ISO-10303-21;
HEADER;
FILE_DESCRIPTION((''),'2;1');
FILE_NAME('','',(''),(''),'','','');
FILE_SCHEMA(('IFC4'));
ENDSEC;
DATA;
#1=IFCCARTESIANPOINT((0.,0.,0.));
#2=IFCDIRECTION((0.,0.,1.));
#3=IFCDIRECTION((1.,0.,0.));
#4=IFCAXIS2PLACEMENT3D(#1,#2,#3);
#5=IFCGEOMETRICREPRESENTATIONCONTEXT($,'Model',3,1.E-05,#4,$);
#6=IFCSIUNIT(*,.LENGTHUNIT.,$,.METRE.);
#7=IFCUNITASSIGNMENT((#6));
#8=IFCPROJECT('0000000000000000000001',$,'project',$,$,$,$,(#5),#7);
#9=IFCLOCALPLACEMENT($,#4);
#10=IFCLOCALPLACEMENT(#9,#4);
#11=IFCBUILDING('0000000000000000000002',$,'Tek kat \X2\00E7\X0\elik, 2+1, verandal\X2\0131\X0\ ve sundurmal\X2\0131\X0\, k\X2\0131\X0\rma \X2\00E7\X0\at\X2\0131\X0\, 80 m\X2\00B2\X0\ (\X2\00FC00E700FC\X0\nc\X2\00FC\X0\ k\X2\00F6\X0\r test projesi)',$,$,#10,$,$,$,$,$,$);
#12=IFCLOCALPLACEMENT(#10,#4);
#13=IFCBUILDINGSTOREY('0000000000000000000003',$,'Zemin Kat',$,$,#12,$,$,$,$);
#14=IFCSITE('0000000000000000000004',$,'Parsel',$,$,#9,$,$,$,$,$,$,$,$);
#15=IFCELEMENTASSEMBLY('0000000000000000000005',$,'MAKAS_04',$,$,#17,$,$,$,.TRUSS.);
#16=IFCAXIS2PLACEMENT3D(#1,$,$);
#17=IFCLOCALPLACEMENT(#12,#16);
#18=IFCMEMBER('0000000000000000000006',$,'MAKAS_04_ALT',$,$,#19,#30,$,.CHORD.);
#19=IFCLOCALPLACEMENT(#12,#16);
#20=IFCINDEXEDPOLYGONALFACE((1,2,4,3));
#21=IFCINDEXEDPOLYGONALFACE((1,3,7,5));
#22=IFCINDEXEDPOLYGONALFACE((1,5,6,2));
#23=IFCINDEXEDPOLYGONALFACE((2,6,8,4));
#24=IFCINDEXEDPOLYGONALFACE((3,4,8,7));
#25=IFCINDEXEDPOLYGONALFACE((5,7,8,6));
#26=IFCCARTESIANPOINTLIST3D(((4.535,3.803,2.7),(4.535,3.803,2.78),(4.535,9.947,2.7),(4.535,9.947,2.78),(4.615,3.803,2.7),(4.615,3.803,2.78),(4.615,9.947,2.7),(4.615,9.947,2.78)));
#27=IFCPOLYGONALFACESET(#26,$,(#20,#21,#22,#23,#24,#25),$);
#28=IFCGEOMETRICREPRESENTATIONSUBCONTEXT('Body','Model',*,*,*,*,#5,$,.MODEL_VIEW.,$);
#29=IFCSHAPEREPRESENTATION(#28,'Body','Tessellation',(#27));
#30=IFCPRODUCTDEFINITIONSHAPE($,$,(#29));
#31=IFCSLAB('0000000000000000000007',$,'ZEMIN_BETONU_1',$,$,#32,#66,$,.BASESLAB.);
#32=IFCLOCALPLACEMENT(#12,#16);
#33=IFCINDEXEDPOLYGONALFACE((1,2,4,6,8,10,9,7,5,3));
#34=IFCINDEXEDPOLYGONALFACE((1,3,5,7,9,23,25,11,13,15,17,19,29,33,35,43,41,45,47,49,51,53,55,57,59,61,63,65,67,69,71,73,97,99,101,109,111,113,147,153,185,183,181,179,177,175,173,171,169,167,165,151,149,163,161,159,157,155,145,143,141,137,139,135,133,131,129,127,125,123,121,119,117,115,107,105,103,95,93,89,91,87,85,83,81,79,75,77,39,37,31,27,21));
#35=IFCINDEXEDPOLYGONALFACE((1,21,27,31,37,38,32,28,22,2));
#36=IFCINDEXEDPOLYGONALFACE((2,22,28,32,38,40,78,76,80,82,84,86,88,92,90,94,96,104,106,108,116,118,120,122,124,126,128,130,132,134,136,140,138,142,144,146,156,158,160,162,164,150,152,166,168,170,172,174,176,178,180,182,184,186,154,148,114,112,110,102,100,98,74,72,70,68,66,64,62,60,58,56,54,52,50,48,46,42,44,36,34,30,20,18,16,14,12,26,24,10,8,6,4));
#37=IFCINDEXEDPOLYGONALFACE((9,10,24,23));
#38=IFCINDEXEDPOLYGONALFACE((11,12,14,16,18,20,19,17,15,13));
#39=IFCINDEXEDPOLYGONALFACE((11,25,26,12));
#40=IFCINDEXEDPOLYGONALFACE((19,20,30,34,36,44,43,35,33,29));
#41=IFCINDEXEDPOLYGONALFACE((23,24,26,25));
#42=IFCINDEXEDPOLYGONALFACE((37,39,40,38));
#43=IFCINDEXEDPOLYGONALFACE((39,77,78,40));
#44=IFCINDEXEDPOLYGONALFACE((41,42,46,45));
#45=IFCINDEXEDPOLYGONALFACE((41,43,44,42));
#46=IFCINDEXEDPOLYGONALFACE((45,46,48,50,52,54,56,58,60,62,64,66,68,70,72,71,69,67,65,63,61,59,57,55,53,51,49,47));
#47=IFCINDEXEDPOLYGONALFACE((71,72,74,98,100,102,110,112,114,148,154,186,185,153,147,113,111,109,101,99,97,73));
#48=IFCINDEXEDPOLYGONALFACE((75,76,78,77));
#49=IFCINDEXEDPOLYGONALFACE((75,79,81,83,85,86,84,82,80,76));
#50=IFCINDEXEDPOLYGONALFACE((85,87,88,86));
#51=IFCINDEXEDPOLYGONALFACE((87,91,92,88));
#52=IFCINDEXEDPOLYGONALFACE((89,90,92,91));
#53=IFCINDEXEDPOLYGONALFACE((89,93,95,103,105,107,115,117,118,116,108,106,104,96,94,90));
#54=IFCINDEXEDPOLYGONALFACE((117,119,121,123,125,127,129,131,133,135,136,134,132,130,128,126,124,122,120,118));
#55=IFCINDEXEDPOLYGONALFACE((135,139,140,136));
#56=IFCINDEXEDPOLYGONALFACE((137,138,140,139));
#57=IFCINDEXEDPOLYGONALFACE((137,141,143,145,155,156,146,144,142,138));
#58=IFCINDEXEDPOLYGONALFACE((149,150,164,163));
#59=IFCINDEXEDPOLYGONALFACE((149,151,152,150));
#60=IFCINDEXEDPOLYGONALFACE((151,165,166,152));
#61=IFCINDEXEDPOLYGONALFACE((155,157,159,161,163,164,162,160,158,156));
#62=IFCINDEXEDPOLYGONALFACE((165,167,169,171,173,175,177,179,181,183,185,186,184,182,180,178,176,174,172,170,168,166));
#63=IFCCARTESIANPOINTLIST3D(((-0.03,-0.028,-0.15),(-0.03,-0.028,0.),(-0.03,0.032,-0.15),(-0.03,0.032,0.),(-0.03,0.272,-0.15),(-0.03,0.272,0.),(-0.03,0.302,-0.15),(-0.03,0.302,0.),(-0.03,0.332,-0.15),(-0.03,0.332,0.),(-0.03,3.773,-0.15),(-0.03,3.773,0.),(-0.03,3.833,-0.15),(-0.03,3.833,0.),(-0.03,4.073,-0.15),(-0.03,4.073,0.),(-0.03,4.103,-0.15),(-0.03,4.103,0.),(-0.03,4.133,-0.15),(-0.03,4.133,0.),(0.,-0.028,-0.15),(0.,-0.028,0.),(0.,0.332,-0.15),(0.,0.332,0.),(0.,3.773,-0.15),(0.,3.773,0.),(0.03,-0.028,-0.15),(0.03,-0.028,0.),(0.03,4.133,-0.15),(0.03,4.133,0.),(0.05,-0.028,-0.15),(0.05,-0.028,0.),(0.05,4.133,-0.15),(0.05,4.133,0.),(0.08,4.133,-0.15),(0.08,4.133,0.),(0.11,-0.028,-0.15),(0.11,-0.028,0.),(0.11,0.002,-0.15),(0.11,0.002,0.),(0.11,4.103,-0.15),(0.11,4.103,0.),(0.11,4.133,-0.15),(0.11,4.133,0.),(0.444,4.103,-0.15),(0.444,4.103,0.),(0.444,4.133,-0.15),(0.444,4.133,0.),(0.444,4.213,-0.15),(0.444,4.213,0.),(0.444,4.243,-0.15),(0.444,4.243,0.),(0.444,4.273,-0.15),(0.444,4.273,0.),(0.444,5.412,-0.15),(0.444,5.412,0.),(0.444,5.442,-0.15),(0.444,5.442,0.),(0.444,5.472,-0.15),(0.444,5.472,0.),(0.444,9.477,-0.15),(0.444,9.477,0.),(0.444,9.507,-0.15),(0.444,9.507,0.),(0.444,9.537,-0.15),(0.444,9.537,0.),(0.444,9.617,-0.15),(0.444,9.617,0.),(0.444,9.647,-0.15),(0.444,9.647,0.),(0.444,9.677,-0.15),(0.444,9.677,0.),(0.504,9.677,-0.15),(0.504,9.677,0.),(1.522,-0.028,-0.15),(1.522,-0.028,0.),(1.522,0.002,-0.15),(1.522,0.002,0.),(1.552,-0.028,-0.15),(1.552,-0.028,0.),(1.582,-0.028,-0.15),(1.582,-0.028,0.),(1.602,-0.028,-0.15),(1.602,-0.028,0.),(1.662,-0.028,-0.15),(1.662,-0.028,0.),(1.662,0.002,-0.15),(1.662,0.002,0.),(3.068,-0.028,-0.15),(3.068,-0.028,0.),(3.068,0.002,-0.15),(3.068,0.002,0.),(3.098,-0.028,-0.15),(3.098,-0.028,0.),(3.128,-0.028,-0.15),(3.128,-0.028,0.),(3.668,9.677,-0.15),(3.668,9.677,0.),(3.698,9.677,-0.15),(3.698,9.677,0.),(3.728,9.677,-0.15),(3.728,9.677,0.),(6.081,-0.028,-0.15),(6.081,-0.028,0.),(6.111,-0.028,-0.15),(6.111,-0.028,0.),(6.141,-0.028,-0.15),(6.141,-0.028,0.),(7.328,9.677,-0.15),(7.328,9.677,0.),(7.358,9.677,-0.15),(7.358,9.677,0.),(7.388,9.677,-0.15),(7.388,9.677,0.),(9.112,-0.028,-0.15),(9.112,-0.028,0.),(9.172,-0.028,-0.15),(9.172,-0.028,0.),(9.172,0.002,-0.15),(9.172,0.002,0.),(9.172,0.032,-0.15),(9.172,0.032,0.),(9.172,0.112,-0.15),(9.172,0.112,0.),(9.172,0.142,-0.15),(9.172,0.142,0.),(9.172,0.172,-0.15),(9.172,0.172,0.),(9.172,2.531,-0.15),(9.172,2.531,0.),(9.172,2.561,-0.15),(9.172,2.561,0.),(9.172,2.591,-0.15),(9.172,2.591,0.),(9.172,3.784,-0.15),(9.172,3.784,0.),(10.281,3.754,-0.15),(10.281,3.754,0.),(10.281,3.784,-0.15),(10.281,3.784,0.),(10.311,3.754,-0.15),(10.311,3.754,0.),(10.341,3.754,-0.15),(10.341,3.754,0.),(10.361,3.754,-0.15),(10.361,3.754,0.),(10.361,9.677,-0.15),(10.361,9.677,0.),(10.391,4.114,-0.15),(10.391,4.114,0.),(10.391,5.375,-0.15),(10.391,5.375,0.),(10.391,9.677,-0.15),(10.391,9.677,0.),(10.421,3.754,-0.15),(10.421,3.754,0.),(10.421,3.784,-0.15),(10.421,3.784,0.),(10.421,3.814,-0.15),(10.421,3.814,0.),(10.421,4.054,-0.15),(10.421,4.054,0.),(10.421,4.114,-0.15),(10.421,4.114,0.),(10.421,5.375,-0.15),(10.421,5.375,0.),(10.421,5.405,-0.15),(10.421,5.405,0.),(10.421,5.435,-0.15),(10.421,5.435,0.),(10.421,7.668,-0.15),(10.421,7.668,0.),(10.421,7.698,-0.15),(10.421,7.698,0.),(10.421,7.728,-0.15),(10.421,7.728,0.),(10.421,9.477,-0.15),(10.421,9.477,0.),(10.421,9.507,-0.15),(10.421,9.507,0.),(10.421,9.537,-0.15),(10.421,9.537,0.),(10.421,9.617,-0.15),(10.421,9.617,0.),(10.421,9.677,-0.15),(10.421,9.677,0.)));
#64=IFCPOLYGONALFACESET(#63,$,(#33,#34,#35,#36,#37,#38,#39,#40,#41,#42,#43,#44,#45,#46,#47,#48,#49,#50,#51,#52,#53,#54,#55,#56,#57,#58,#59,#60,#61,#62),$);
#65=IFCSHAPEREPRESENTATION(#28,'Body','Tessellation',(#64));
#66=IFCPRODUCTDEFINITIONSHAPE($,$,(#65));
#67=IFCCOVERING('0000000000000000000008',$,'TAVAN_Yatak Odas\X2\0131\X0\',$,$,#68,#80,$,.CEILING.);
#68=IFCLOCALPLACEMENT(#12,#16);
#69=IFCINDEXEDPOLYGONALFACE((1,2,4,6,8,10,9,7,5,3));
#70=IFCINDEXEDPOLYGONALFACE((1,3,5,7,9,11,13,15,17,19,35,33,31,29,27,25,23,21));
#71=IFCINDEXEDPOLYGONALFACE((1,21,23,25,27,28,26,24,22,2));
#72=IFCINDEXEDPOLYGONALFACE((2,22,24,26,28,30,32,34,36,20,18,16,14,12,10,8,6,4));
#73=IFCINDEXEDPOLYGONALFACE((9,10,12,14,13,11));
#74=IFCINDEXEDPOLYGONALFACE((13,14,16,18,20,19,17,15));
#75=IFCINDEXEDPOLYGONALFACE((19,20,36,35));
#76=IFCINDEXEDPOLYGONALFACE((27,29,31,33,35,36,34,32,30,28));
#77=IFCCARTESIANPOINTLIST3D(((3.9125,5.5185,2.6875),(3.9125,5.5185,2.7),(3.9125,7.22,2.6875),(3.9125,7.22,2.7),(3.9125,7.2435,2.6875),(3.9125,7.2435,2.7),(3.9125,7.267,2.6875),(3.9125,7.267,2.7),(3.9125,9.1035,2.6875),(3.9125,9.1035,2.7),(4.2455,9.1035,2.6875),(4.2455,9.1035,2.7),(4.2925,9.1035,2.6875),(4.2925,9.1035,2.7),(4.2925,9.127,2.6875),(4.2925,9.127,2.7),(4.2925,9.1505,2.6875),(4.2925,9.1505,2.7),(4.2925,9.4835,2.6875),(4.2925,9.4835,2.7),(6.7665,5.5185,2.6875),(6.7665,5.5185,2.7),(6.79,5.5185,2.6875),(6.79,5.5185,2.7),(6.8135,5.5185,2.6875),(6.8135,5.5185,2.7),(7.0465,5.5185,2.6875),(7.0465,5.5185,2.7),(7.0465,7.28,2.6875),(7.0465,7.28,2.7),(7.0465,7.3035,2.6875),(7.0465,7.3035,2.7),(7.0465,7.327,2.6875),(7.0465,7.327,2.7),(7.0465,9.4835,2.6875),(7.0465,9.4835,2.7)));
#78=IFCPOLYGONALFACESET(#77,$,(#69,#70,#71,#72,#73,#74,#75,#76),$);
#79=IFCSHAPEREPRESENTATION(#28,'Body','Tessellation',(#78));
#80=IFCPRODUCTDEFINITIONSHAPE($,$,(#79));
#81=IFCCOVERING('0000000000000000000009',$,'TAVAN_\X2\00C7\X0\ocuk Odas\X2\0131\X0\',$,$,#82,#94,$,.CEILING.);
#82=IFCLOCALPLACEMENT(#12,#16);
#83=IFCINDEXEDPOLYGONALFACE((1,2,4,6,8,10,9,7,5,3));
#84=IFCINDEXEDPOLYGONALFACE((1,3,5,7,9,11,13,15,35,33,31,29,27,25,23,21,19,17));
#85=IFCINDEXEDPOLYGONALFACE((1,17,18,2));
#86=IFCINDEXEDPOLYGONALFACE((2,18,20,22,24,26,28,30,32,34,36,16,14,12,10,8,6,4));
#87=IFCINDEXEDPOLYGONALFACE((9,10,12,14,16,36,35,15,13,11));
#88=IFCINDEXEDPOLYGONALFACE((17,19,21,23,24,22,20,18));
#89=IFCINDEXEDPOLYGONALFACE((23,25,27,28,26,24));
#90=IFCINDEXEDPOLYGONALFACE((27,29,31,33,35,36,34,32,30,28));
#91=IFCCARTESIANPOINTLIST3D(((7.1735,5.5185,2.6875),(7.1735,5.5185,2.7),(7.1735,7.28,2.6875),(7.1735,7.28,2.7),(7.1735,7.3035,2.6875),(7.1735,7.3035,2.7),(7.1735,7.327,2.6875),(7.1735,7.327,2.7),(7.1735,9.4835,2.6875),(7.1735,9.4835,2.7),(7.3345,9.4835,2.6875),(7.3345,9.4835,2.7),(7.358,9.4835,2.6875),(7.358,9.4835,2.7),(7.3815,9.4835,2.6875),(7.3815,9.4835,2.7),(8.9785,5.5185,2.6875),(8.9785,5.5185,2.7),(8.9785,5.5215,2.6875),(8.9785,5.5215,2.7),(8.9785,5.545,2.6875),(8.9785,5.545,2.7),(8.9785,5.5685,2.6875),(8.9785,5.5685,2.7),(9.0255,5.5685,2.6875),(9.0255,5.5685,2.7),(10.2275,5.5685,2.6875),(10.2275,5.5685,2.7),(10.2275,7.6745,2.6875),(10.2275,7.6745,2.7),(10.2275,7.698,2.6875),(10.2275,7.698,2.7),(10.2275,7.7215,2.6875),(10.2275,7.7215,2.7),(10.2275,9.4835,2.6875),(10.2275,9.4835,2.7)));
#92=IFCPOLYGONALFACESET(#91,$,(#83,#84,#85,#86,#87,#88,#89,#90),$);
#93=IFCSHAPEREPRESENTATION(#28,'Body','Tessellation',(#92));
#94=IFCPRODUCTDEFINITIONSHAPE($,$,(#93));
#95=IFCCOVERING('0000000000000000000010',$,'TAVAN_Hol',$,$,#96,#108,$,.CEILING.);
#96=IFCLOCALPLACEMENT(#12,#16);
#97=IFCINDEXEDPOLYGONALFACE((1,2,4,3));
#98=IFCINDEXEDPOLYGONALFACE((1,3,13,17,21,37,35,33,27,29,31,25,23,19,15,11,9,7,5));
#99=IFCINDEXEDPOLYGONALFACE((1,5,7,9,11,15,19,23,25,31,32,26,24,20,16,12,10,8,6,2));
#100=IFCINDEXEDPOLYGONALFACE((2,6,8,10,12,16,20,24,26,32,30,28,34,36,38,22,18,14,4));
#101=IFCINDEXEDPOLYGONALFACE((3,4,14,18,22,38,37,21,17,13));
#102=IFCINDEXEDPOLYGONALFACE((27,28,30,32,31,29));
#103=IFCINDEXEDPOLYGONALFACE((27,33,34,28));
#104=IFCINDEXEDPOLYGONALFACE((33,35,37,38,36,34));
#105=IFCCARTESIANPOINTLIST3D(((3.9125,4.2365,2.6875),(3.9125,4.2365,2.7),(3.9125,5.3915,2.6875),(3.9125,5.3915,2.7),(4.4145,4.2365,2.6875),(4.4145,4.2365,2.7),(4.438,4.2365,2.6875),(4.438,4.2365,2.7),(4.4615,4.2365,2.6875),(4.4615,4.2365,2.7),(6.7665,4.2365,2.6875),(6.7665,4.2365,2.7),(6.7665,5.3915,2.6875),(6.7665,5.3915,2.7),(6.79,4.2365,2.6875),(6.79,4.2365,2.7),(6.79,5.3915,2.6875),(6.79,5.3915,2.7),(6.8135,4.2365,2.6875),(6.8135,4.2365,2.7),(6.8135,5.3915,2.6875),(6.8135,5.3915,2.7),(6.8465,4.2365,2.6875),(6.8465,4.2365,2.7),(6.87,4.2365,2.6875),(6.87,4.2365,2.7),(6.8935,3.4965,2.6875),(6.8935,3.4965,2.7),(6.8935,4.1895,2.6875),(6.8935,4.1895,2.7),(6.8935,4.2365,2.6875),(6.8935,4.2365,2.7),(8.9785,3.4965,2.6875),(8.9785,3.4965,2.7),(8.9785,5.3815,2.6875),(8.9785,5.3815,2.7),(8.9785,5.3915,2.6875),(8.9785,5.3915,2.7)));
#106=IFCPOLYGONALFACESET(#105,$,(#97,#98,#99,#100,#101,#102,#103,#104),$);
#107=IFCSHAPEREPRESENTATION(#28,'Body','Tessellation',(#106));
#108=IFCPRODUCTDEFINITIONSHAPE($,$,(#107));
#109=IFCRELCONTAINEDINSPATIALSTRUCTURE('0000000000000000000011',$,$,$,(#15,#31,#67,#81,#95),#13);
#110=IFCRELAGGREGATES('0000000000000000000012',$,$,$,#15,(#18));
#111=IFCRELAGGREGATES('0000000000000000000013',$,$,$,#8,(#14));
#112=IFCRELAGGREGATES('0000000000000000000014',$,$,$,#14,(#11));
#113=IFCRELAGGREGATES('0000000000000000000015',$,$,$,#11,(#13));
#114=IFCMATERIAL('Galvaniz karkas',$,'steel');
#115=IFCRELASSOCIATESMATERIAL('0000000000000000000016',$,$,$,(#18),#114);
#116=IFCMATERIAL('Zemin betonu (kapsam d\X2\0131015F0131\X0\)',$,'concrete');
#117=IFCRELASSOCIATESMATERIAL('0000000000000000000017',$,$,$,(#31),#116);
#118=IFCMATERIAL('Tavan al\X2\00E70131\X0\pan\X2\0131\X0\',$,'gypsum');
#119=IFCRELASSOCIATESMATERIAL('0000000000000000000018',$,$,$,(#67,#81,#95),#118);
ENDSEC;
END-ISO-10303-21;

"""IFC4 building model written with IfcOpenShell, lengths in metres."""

from ifc_helpers import new_model, si_unit, frame, origin_with_axes, place, context, subcontext, project, spatial, line, indexed_curve, outline, extrude, material, element, aggregate, save


model = new_model("IFC4")

# Units and contexts
model_context = context("Model", 3, precision=1e-05, world=origin_with_axes())
body_context = subcontext(model_context, "Body", "Model", "MODEL_VIEW")
ifc_project = project(units=[si_unit("LENGTHUNIT", "METRE")], contexts=[model_context])

# Site, building, storey
site_placement = place(None, origin_with_axes())
site = spatial("IfcSite", under=ifc_project, at=site_placement, Name="Parsel")
building_placement = place(site_placement, origin_with_axes())
building = spatial("IfcBuilding", under=site, at=building_placement, Name="Tek kat çelik, 2+1, verandalı ve sundurmalı, kırma çatı, 80 m² (üçüncü kör test projesi)")
storey_placement = place(building_placement, origin_with_axes())
storey = spatial("IfcBuildingStorey", under=building, at=storey_placement, Name="Zemin Kat")

# Shared definitions
ifc_material_1 = material(Name="Galvaniz karkas", Category="steel")

# Element assembly, member
assembly_1_placement = place(storey_placement, origin_with_axes())
assembly_1 = element("IfcElementAssembly", 1, at=assembly_1_placement, inside=storey, Name="MAKAS_04", PredefinedType="TRUSS")
member_1_placement = place(assembly_1_placement, origin_with_axes())
member_1 = element("IfcMember", 2, at=member_1_placement, material=ifc_material_1, Name="MAKAS_04_ALT", PredefinedType="CHORD", context=body_context, shape_type="SweptSolid", body=[
    extrude(outline(indexed_curve([(3.803, 2.7), (9.947, 2.7), (9.947, 2.78), (3.803, 2.78)], segments=[line(1, 2, 3, 4, 1)])), frame((4.535, 0.0, 0.0), z_axis=(1.0, 0.0, 0.0), x_axis=(0.0, 1.0, 0.0)), (0.0, 0.0, 1.0), 0.08),
])
aggregate(assembly_1, [member_1])

# Slab
ifc_material_2 = material(Name="Zemin betonu (kapsam dışı)", Category="concrete")
slab_placement = place(storey_placement, origin_with_axes())
element("IfcSlab", 3, at=slab_placement, inside=storey, material=ifc_material_2, Name="ZEMIN_BETONU_1", PredefinedType="BASESLAB", context=body_context, shape_type="SweptSolid", body=[
    extrude(outline(indexed_curve([(3.068, 0.002), (3.068, -0.028), (3.098, -0.028), (3.128, -0.028), (6.081, -0.028), (6.111, -0.028), (6.141, -0.028), (9.112, -0.028), (9.172, -0.028), (9.172, 0.002), (9.172, 0.032), (9.172, 0.112), (9.172, 0.142), (9.172, 0.172), (9.172, 2.531), (9.172, 2.561), (9.172, 2.591), (9.172, 3.784), (10.281, 3.784), (10.281, 3.754), (10.311, 3.754), (10.341, 3.754), (10.361, 3.754), (10.421, 3.754), (10.421, 3.784), (10.421, 3.814), (10.421, 4.054), (10.421, 4.114), (10.391, 4.114), (10.391, 5.375), (10.421, 5.375), (10.421, 5.405), (10.421, 5.435), (10.421, 7.668), (10.421, 7.698), (10.421, 7.728), (10.421, 9.477), (10.421, 9.507), (10.421, 9.537), (10.421, 9.617), (10.421, 9.677), (10.391, 9.677), (10.361, 9.677), (7.388, 9.677), (7.358, 9.677), (7.328, 9.677), (3.728, 9.677), (3.698, 9.677), (3.668, 9.677), (0.504, 9.677), (0.444, 9.677), (0.444, 9.647), (0.444, 9.617), (0.444, 9.537), (0.444, 9.507), (0.444, 9.477), (0.444, 5.472), (0.444, 5.442), (0.444, 5.412), (0.444, 4.273), (0.444, 4.243), (0.444, 4.213), (0.444, 4.133), (0.444, 4.103), (0.11, 4.103), (0.11, 4.133), (0.08, 4.133), (0.05, 4.133), (0.03, 4.133), (-0.03, 4.133), (-0.03, 4.103), (-0.03, 4.073), (-0.03, 3.833), (-0.03, 3.773), (0.0, 3.773), (0.0, 0.332), (-0.03, 0.332), (-0.03, 0.302), (-0.03, 0.272), (-0.03, 0.032), (-0.03, -0.028), (0.0, -0.028), (0.03, -0.028), (0.05, -0.028), (0.11, -0.028), (0.11, 0.002), (1.522, 0.002), (1.522, -0.028), (1.552, -0.028), (1.582, -0.028), (1.602, -0.028), (1.662, -0.028), (1.662, 0.002)], segments=[line(1, 2, 3, 4, 5, 6, 7, 8, 9, 10, 11, 12, 13, 14, 15, 16, 17, 18, 19, 20, 21, 22, 23, 24, 25, 26, 27, 28, 29, 30, 31, 32, 33, 34, 35, 36, 37, 38, 39, 40, 41, 42, 43, 44, 45, 46, 47, 48, 49, 50, 51, 52, 53, 54, 55, 56, 57, 58, 59, 60, 61, 62, 63, 64, 65, 66, 67, 68, 69, 70, 71, 72, 73, 74, 75, 76, 77, 78, 79, 80, 81, 82, 83, 84, 85, 86, 87, 88, 89, 90, 91, 92, 93, 1)])), frame((0.0, 0.0, -0.15), z_axis=(0.0, 0.0, 1.0), x_axis=(1.0, 0.0, 0.0)), (0.0, 0.0, 1.0), 0.15),
])

# Coverings
ifc_material_3 = material(Name="Tavan alçıpanı", Category="gypsum")
covering_1_placement = place(storey_placement, origin_with_axes())
element("IfcCovering", 4, at=covering_1_placement, inside=storey, material=ifc_material_3, Name="TAVAN_Yatak Odası", PredefinedType="CEILING", context=body_context, shape_type="SweptSolid", body=[
    extrude(outline(indexed_curve([(4.2925, 9.4835), (7.0465, 9.4835), (7.0465, 7.327), (7.0465, 7.3035), (7.0465, 7.28), (7.0465, 5.5185), (6.8135, 5.5185), (6.79, 5.5185), (6.7665, 5.5185), (3.9125, 5.5185), (3.9125, 7.22), (3.9125, 7.2435), (3.9125, 7.267), (3.9125, 9.1035), (4.2455, 9.1035), (4.2925, 9.1035), (4.2925, 9.127), (4.2925, 9.1505)], segments=[line(1, 2, 3, 4, 5, 6, 7, 8, 9, 10, 11, 12, 13, 14, 15, 16, 17, 18, 1)])), frame((0.0, 0.0, 2.6875), z_axis=(0.0, 0.0, 1.0), x_axis=(1.0, 0.0, 0.0)), (0.0, 0.0, 1.0), 0.0125),
])
covering_2_placement = place(storey_placement, origin_with_axes())
element("IfcCovering", 5, at=covering_2_placement, inside=storey, material=ifc_material_3, Name="TAVAN_Çocuk Odası", PredefinedType="CEILING", context=body_context, shape_type="SweptSolid", body=[
    extrude(outline(indexed_curve([(7.3815, 9.4835), (10.2275, 9.4835), (10.2275, 7.7215), (10.2275, 7.698), (10.2275, 7.6745), (10.2275, 5.5685), (9.0255, 5.5685), (8.9785, 5.5685), (8.9785, 5.545), (8.9785, 5.5215), (8.9785, 5.5185), (7.1735, 5.5185), (7.1735, 7.28), (7.1735, 7.3035), (7.1735, 7.327), (7.1735, 9.4835), (7.3345, 9.4835), (7.358, 9.4835)], segments=[line(1, 2, 3, 4, 5, 6, 7, 8, 9, 10, 11, 12, 13, 14, 15, 16, 17, 18, 1)])), frame((0.0, 0.0, 2.6875), z_axis=(0.0, 0.0, 1.0), x_axis=(1.0, 0.0, 0.0)), (0.0, 0.0, 1.0), 0.0125),
])
covering_3_placement = place(storey_placement, origin_with_axes())
element("IfcCovering", 6, at=covering_3_placement, inside=storey, material=ifc_material_3, Name="TAVAN_Hol", PredefinedType="CEILING", context=body_context, shape_type="SweptSolid", body=[
    extrude(outline(indexed_curve([(4.4145, 4.2365), (3.9125, 4.2365), (3.9125, 5.3915), (6.7665, 5.3915), (6.79, 5.3915), (6.8135, 5.3915), (8.9785, 5.3915), (8.9785, 5.3815), (8.9785, 3.4965), (6.8935, 3.4965), (6.8935, 4.1895), (6.8935, 4.2365), (6.87, 4.2365), (6.8465, 4.2365), (6.8135, 4.2365), (6.79, 4.2365), (6.7665, 4.2365), (4.4615, 4.2365), (4.438, 4.2365)], segments=[line(1, 2, 3, 4, 5, 6, 7, 8, 9, 10, 11, 12, 13, 14, 15, 16, 17, 18, 19, 1)])), frame((0.0, 0.0, 2.6875), z_axis=(0.0, 0.0, 1.0), x_axis=(1.0, 0.0, 0.0)), (0.0, 0.0, 1.0), 0.0125),
])

save(model, "model.ifc")
